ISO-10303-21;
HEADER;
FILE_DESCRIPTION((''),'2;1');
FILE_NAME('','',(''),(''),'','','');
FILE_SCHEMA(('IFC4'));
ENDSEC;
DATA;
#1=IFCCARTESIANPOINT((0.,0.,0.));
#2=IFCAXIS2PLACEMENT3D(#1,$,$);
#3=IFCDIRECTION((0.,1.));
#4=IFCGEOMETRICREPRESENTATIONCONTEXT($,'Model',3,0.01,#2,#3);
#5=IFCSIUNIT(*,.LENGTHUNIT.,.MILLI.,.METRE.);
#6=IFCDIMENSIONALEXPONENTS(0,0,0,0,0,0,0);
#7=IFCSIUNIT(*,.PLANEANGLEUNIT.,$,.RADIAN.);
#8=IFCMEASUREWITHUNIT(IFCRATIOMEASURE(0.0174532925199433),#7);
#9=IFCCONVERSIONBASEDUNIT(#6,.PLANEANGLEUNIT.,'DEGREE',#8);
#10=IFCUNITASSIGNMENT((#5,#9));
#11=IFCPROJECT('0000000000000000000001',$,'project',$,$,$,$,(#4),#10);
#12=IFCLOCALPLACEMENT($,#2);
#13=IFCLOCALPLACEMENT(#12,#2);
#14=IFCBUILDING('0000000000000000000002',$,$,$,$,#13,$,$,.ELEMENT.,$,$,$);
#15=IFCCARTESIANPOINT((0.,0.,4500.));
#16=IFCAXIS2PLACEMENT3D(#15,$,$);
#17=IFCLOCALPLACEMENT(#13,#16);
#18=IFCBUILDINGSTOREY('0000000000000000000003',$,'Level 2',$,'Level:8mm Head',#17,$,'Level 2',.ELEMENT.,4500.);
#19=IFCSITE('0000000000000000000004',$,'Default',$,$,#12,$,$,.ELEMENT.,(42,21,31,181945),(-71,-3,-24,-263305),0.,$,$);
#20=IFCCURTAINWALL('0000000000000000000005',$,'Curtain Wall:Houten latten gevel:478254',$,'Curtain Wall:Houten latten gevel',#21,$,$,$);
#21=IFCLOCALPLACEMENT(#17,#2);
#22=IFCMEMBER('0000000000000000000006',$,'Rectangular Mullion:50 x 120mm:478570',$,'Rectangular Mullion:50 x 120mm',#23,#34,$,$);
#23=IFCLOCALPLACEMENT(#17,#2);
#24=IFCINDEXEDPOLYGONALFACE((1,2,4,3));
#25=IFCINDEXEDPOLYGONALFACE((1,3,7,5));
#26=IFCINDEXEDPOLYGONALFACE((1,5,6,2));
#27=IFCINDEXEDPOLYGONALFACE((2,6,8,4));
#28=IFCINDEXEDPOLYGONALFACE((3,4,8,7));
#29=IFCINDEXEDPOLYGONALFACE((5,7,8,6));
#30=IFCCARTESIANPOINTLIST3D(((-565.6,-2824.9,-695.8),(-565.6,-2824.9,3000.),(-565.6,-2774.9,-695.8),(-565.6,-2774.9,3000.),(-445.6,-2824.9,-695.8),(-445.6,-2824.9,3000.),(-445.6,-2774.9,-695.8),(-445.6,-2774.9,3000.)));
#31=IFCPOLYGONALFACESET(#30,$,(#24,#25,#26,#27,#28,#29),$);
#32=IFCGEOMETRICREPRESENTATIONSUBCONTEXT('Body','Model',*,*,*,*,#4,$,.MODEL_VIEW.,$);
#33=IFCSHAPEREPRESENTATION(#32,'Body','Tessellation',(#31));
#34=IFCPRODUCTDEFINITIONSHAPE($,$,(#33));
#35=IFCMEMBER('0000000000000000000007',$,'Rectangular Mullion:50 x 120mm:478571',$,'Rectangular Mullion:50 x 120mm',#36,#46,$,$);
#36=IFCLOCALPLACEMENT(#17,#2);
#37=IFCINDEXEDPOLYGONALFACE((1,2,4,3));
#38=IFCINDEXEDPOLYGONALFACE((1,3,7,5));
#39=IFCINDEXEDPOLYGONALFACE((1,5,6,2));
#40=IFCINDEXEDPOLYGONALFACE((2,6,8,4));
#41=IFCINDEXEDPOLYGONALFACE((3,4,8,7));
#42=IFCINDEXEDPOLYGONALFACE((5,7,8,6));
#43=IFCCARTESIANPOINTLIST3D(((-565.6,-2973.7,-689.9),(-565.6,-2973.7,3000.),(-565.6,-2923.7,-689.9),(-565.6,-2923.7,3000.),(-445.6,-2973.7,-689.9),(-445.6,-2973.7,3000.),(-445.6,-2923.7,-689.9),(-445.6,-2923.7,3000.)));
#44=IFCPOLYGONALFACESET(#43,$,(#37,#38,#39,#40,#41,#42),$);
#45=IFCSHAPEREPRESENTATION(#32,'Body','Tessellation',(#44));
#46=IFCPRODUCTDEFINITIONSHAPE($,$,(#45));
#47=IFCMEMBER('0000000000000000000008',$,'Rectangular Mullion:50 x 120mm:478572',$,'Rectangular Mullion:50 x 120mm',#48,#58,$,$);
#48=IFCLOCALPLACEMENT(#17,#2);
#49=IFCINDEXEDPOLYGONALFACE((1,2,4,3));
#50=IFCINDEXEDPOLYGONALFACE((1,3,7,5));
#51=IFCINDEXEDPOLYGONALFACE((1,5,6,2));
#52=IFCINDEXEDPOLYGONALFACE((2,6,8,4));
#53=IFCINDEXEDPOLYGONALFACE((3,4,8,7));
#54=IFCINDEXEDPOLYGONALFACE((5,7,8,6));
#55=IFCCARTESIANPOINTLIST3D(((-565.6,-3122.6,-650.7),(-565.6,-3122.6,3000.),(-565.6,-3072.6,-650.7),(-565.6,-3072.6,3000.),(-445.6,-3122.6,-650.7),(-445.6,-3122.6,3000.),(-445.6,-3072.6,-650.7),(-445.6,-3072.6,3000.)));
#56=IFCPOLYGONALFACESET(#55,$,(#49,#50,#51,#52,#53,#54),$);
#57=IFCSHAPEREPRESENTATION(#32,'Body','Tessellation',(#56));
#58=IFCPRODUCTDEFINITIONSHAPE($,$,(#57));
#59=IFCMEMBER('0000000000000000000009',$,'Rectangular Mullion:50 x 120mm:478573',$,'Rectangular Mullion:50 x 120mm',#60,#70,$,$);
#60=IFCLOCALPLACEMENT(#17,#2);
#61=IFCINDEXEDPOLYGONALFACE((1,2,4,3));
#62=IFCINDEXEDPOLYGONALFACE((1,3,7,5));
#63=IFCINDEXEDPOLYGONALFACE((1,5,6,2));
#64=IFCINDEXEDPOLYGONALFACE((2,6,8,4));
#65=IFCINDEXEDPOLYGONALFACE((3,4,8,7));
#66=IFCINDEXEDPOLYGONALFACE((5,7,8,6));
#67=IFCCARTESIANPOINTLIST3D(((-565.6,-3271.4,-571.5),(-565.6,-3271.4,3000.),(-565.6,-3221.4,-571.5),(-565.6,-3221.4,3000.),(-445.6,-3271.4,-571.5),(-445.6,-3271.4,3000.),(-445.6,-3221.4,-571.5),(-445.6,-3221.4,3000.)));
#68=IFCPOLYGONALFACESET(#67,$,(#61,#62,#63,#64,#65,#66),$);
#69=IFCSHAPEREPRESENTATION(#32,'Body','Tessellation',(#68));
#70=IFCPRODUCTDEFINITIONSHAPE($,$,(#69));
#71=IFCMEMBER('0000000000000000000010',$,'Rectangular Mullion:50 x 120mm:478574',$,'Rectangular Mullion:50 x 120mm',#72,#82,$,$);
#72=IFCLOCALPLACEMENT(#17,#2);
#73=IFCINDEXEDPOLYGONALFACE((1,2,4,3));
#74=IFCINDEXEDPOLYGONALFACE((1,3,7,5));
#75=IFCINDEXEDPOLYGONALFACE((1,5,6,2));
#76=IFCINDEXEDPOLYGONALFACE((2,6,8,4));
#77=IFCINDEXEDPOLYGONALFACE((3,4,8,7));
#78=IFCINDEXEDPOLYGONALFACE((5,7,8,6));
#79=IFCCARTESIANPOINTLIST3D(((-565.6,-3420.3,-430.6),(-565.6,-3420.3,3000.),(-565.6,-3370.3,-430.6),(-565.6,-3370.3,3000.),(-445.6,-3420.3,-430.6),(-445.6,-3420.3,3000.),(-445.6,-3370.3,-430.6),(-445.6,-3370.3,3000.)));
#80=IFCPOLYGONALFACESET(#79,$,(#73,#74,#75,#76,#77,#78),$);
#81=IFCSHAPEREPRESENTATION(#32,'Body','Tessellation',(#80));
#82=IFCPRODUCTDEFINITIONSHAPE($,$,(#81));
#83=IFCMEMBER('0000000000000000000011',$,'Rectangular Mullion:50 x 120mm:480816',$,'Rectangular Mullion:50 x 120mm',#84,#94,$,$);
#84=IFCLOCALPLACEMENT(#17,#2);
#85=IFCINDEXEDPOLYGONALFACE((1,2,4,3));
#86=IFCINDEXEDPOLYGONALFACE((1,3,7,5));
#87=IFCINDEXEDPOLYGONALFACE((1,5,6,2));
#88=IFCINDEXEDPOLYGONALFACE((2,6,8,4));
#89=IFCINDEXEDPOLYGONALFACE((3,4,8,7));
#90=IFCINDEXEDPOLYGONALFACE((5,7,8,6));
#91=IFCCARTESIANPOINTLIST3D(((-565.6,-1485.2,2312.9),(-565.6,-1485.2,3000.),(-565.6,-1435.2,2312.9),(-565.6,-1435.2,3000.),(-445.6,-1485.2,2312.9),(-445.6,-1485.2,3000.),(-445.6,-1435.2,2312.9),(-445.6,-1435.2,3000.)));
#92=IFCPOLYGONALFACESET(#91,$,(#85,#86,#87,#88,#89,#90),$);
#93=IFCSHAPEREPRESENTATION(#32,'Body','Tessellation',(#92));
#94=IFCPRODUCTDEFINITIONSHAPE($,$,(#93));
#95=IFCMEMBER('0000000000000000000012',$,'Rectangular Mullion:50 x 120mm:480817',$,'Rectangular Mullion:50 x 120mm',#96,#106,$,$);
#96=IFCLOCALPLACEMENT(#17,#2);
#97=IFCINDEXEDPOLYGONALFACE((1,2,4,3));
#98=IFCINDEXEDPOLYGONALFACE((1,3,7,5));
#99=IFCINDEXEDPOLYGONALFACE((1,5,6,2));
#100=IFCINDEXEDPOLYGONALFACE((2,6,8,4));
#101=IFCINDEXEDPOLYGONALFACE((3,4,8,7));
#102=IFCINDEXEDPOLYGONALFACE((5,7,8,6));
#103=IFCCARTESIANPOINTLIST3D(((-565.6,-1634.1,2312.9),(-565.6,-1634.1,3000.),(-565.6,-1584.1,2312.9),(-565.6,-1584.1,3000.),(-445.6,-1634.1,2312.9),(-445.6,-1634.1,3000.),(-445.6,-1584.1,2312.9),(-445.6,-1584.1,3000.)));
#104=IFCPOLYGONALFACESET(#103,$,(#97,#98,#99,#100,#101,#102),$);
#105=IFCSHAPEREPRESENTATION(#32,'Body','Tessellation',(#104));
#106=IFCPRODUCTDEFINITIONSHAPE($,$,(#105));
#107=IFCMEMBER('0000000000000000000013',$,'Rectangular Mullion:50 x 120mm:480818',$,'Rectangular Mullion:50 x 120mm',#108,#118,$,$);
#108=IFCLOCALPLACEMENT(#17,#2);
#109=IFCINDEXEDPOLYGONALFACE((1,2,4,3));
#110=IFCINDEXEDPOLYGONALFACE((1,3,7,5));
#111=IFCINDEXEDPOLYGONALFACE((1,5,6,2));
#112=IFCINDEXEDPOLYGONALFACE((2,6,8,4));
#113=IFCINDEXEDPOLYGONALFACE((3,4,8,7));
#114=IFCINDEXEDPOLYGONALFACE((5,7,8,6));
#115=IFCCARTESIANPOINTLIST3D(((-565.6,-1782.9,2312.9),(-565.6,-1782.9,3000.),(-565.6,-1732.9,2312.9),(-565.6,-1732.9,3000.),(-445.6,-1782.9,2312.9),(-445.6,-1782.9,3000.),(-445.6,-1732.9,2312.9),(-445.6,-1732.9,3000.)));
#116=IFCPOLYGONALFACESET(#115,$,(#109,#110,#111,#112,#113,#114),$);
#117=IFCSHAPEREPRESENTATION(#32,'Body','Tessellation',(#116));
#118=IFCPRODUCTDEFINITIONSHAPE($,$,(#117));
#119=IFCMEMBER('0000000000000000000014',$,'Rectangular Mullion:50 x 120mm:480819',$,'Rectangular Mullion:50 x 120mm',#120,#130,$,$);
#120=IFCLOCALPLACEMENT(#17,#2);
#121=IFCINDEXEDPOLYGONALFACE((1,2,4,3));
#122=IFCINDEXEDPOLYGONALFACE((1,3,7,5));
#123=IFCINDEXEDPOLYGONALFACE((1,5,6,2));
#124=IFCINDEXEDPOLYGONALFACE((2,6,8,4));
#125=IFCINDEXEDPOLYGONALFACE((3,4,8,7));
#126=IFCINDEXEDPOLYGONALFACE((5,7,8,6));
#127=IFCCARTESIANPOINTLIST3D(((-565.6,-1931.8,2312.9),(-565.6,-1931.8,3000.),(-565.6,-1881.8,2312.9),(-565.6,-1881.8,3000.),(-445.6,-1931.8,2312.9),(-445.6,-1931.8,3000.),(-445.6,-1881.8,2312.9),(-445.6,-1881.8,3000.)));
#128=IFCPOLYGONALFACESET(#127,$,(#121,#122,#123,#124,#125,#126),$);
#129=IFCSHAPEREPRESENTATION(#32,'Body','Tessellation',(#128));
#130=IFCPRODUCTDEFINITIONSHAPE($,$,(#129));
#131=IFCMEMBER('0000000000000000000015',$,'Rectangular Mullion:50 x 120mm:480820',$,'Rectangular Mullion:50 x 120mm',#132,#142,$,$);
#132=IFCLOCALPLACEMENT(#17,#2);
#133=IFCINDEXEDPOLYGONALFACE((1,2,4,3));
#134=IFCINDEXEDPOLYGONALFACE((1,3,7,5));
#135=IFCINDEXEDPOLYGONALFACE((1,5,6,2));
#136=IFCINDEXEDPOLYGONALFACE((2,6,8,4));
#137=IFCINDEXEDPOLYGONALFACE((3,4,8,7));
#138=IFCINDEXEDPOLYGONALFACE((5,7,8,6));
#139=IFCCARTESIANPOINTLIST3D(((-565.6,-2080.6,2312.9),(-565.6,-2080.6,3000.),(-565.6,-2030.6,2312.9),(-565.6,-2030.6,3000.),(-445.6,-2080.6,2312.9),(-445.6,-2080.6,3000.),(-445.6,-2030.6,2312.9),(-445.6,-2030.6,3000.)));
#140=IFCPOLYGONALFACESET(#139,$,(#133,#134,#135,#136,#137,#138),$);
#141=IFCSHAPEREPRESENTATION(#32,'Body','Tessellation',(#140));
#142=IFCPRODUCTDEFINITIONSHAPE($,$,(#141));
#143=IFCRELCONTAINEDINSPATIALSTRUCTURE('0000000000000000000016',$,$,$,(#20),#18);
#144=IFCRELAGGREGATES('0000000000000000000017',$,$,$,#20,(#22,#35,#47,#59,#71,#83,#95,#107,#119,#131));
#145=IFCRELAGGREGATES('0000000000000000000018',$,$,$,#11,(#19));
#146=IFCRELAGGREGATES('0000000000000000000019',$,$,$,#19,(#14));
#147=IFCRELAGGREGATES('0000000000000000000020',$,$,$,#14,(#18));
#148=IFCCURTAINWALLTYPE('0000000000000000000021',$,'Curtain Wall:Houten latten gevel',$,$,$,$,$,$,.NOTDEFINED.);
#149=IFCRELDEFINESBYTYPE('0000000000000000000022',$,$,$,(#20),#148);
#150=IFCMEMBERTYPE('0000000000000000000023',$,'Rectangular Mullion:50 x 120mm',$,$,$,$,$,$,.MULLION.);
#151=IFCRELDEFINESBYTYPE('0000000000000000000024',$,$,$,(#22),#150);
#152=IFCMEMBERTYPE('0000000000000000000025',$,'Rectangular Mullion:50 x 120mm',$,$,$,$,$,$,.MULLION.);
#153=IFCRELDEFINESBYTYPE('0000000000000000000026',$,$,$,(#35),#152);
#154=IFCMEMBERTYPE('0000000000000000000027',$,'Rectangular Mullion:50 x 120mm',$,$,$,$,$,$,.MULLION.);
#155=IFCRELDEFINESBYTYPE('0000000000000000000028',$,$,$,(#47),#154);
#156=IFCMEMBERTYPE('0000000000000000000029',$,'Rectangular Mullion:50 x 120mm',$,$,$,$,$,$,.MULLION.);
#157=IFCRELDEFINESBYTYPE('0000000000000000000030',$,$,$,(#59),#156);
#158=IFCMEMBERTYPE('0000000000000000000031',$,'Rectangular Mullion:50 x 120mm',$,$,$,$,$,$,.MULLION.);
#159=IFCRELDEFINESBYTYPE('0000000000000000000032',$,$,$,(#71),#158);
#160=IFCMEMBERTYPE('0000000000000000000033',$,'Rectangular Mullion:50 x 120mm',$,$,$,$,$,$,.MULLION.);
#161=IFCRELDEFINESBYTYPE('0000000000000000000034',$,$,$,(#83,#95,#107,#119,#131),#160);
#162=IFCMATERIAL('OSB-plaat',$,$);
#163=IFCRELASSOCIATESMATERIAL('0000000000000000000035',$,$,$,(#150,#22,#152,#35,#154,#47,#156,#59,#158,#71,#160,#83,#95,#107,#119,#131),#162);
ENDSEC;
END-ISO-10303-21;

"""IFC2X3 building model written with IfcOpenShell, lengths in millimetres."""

from ifc_helpers import new_model, entity, si_unit, converted_unit, direction, frame, origin, origin_2d_with_axis, place, context, subcontext, project, spatial, rectangle, extrude, source, transform, mapped, material, type_object, type_shapes, element, aggregate, save


model = new_model("IFC2X3")

# Units and contexts
model_context = context("Model", 3, precision=0.01, world=origin(), true_north=direction((0.0, 1.0)))
body_context = subcontext(model_context, "Body", "Model", "MODEL_VIEW")
ifc_project = project(units=[si_unit("LENGTHUNIT", "METRE", prefix="MILLI"), converted_unit("PLANEANGLEUNIT", "DEGREE", entity("IfcRatioMeasure", 0.0174532925199433), si_unit("PLANEANGLEUNIT", "RADIAN"), dimensions=[0, 0, 0, 0, 0, 0, 0])], contexts=[model_context])

# Site, building, storey
site_placement = place(None, frame((0.0, 0.0, 0.0)))
site = spatial("IfcSite", under=ifc_project, at=site_placement, Name="Default", CompositionType="ELEMENT", RefLatitude=(42, 21, 31, 181945), RefLongitude=(-71, -3, -24, -263305), RefElevation=0.0)
building_placement = place(site_placement, origin())
building = spatial("IfcBuilding", under=site, at=building_placement, CompositionType="ELEMENT")
storey_placement = place(building_placement, frame((0.0, 0.0, 4500.0)))
storey = spatial("IfcBuildingStorey", under=building, at=storey_placement, Name="Level 2", ObjectType="Level:8mm Head", LongName="Level 2", CompositionType="ELEMENT", Elevation=4500.0)

# Curtain wall, members
curtain_wall_type = type_object("IfcCurtainWallType", Name="Curtain Wall:Houten latten gevel", PredefinedType="NOTDEFINED")
ifc_material_1 = material(Name="OSB-plaat")
curtain_wall_1_placement = place(storey_placement, frame((0.0, 0.0, -4500.0)))
curtain_wall_1 = element("IfcCurtainWall", 1, at=curtain_wall_1_placement, inside=storey, type_object=curtain_wall_type, Name="Curtain Wall:Houten latten gevel:478254", ObjectType="Curtain Wall:Houten latten gevel")
member_type_1 = type_object("IfcMemberType", Name="Rectangular Mullion:50 x 120mm", PredefinedType="MULLION", material=ifc_material_1)
shared_shape_1 = source(origin(), body_context, "Body", "SweptSolid", [
    extrude(rectangle(XDim=120.0, YDim=50.0, at=origin_2d_with_axis()), frame((0.0, 0.0, -3695.8), z_axis=(0.0, 0.0, 1.0), x_axis=(0.0, -1.0, 0.0)), (0.0, 0.0, 1.0), 3695.8),
])
type_shapes(member_type_1, [shared_shape_1])
member_1_placement = place(storey_placement, frame((-505.6, -2799.9, -695.8), z_axis=(0.0, 0.0, -1.0), x_axis=(0.0, -1.0, 0.0)))
member_1 = element("IfcMember", 2, at=member_1_placement, type_object=member_type_1, material=ifc_material_1, Name="Rectangular Mullion:50 x 120mm:478570", ObjectType="Rectangular Mullion:50 x 120mm", context=body_context, shape_type="MappedRepresentation", body=[
    mapped(shared_shape_1, transform((0.0, 0.0, 0.0), scale=1.0)),
])
member_type_2 = type_object("IfcMemberType", Name="Rectangular Mullion:50 x 120mm", PredefinedType="MULLION", material=ifc_material_1)
shared_shape_2 = source(origin(), body_context, "Body", "SweptSolid", [
    extrude(rectangle(XDim=120.0, YDim=50.0, at=origin_2d_with_axis()), frame((0.0, 0.0, -3689.9), z_axis=(0.0, 0.0, 1.0), x_axis=(0.0, -1.0, 0.0)), (0.0, 0.0, 1.0), 3689.9),
])
type_shapes(member_type_2, [shared_shape_2])
member_2_placement = place(storey_placement, frame((-505.6, -2948.7, -689.9), z_axis=(0.0, 0.0, -1.0), x_axis=(0.0, -1.0, 0.0)))
member_2 = element("IfcMember", 3, at=member_2_placement, type_object=member_type_2, material=ifc_material_1, Name="Rectangular Mullion:50 x 120mm:478571", ObjectType="Rectangular Mullion:50 x 120mm", context=body_context, shape_type="MappedRepresentation", body=[
    mapped(shared_shape_2, transform((0.0, 0.0, 0.0), scale=1.0)),
])
member_type_3 = type_object("IfcMemberType", Name="Rectangular Mullion:50 x 120mm", PredefinedType="MULLION", material=ifc_material_1)
shared_shape_3 = source(origin(), body_context, "Body", "SweptSolid", [
    extrude(rectangle(XDim=120.0, YDim=50.0, at=origin_2d_with_axis()), frame((0.0, 0.0, -3650.7), z_axis=(0.0, 0.0, 1.0), x_axis=(0.0, -1.0, 0.0)), (0.0, 0.0, 1.0), 3650.7),
])
type_shapes(member_type_3, [shared_shape_3])
member_3_placement = place(storey_placement, frame((-505.6, -3097.6, -650.7), z_axis=(0.0, 0.0, -1.0), x_axis=(0.0, -1.0, 0.0)))
member_3 = element("IfcMember", 4, at=member_3_placement, type_object=member_type_3, material=ifc_material_1, Name="Rectangular Mullion:50 x 120mm:478572", ObjectType="Rectangular Mullion:50 x 120mm", context=body_context, shape_type="MappedRepresentation", body=[
    mapped(shared_shape_3, transform((0.0, 0.0, 0.0), scale=1.0)),
])
member_type_4 = type_object("IfcMemberType", Name="Rectangular Mullion:50 x 120mm", PredefinedType="MULLION", material=ifc_material_1)
shared_shape_4 = source(origin(), body_context, "Body", "SweptSolid", [
    extrude(rectangle(XDim=120.0, YDim=50.0, at=origin_2d_with_axis()), frame((0.0, 0.0, -3571.5), z_axis=(0.0, 0.0, 1.0), x_axis=(0.0, -1.0, 0.0)), (0.0, 0.0, 1.0), 3571.5),
])
type_shapes(member_type_4, [shared_shape_4])
member_4_placement = place(storey_placement, frame((-505.6, -3246.4, -571.5), z_axis=(0.0, 0.0, -1.0), x_axis=(0.0, -1.0, 0.0)))
member_4 = element("IfcMember", 5, at=member_4_placement, type_object=member_type_4, material=ifc_material_1, Name="Rectangular Mullion:50 x 120mm:478573", ObjectType="Rectangular Mullion:50 x 120mm", context=body_context, shape_type="MappedRepresentation", body=[
    mapped(shared_shape_4, transform((0.0, 0.0, 0.0), scale=1.0)),
])
member_type_5 = type_object("IfcMemberType", Name="Rectangular Mullion:50 x 120mm", PredefinedType="MULLION", material=ifc_material_1)
shared_shape_5 = source(origin(), body_context, "Body", "SweptSolid", [
    extrude(rectangle(XDim=120.0, YDim=50.0, at=origin_2d_with_axis()), frame((0.0, 0.0, -3430.6), z_axis=(0.0, 0.0, 1.0), x_axis=(0.0, -1.0, 0.0)), (0.0, 0.0, 1.0), 3430.6),
])
type_shapes(member_type_5, [shared_shape_5])
member_5_placement = place(storey_placement, frame((-505.6, -3395.3, -430.6), z_axis=(0.0, 0.0, -1.0), x_axis=(0.0, -1.0, 0.0)))
member_5 = element("IfcMember", 6, at=member_5_placement, type_object=member_type_5, material=ifc_material_1, Name="Rectangular Mullion:50 x 120mm:478574", ObjectType="Rectangular Mullion:50 x 120mm", context=body_context, shape_type="MappedRepresentation", body=[
    mapped(shared_shape_5, transform((0.0, 0.0, 0.0), scale=1.0)),
])
member_type_6 = type_object("IfcMemberType", Name="Rectangular Mullion:50 x 120mm", PredefinedType="MULLION", material=ifc_material_1)
shared_shape_6 = source(origin(), body_context, "Body", "SweptSolid", [
    extrude(rectangle(XDim=120.0, YDim=50.0, at=origin_2d_with_axis()), frame((0.0, 0.0, -687.1), z_axis=(0.0, 0.0, 1.0), x_axis=(0.0, -1.0, 0.0)), (0.0, 0.0, 1.0), 687.1),
])
type_shapes(member_type_6, [shared_shape_6])
member_6_placement = place(storey_placement, frame((-505.6, -1460.2, 2312.9), z_axis=(0.0, 0.0, -1.0), x_axis=(0.0, -1.0, 0.0)))
member_6 = element("IfcMember", 7, at=member_6_placement, type_object=member_type_6, material=ifc_material_1, Name="Rectangular Mullion:50 x 120mm:480816", ObjectType="Rectangular Mullion:50 x 120mm", context=body_context, shape_type="MappedRepresentation", body=[
    mapped(shared_shape_6, transform((0.0, 0.0, 0.0), scale=1.0)),
])
member_7_placement = place(storey_placement, frame((-505.6, -1609.1, 2312.9), z_axis=(0.0, 0.0, -1.0), x_axis=(0.0, -1.0, 0.0)))
member_7 = element("IfcMember", 8, at=member_7_placement, type_object=member_type_6, material=ifc_material_1, Name="Rectangular Mullion:50 x 120mm:480817", ObjectType="Rectangular Mullion:50 x 120mm", context=body_context, shape_type="MappedRepresentation", body=[
    mapped(shared_shape_6, transform((0.0, 0.0, 0.0), scale=1.0)),
])
member_8_placement = place(storey_placement, frame((-505.6, -1757.9, 2312.9), z_axis=(0.0, 0.0, -1.0), x_axis=(0.0, -1.0, 0.0)))
member_8 = element("IfcMember", 9, at=member_8_placement, type_object=member_type_6, material=ifc_material_1, Name="Rectangular Mullion:50 x 120mm:480818", ObjectType="Rectangular Mullion:50 x 120mm", context=body_context, shape_type="MappedRepresentation", body=[
    mapped(shared_shape_6, transform((0.0, 0.0, 0.0), scale=1.0)),
])
member_9_placement = place(storey_placement, frame((-505.6, -1906.8, 2312.9), z_axis=(0.0, 0.0, -1.0), x_axis=(0.0, -1.0, 0.0)))
member_9 = element("IfcMember", 10, at=member_9_placement, type_object=member_type_6, material=ifc_material_1, Name="Rectangular Mullion:50 x 120mm:480819", ObjectType="Rectangular Mullion:50 x 120mm", context=body_context, shape_type="MappedRepresentation", body=[
    mapped(shared_shape_6, transform((0.0, 0.0, 0.0), scale=1.0)),
])
member_10_placement = place(storey_placement, frame((-505.6, -2055.6, 2312.9), z_axis=(0.0, 0.0, -1.0), x_axis=(0.0, -1.0, 0.0)))
member_10 = element("IfcMember", 11, at=member_10_placement, type_object=member_type_6, material=ifc_material_1, Name="Rectangular Mullion:50 x 120mm:480820", ObjectType="Rectangular Mullion:50 x 120mm", context=body_context, shape_type="MappedRepresentation", body=[
    mapped(shared_shape_6, transform((0.0, 0.0, 0.0), scale=1.0)),
])
aggregate(curtain_wall_1, [member_1, member_2, member_3, member_4, member_5, member_6, member_7, member_8, member_9, member_10])

save(model, "model.ifc")
